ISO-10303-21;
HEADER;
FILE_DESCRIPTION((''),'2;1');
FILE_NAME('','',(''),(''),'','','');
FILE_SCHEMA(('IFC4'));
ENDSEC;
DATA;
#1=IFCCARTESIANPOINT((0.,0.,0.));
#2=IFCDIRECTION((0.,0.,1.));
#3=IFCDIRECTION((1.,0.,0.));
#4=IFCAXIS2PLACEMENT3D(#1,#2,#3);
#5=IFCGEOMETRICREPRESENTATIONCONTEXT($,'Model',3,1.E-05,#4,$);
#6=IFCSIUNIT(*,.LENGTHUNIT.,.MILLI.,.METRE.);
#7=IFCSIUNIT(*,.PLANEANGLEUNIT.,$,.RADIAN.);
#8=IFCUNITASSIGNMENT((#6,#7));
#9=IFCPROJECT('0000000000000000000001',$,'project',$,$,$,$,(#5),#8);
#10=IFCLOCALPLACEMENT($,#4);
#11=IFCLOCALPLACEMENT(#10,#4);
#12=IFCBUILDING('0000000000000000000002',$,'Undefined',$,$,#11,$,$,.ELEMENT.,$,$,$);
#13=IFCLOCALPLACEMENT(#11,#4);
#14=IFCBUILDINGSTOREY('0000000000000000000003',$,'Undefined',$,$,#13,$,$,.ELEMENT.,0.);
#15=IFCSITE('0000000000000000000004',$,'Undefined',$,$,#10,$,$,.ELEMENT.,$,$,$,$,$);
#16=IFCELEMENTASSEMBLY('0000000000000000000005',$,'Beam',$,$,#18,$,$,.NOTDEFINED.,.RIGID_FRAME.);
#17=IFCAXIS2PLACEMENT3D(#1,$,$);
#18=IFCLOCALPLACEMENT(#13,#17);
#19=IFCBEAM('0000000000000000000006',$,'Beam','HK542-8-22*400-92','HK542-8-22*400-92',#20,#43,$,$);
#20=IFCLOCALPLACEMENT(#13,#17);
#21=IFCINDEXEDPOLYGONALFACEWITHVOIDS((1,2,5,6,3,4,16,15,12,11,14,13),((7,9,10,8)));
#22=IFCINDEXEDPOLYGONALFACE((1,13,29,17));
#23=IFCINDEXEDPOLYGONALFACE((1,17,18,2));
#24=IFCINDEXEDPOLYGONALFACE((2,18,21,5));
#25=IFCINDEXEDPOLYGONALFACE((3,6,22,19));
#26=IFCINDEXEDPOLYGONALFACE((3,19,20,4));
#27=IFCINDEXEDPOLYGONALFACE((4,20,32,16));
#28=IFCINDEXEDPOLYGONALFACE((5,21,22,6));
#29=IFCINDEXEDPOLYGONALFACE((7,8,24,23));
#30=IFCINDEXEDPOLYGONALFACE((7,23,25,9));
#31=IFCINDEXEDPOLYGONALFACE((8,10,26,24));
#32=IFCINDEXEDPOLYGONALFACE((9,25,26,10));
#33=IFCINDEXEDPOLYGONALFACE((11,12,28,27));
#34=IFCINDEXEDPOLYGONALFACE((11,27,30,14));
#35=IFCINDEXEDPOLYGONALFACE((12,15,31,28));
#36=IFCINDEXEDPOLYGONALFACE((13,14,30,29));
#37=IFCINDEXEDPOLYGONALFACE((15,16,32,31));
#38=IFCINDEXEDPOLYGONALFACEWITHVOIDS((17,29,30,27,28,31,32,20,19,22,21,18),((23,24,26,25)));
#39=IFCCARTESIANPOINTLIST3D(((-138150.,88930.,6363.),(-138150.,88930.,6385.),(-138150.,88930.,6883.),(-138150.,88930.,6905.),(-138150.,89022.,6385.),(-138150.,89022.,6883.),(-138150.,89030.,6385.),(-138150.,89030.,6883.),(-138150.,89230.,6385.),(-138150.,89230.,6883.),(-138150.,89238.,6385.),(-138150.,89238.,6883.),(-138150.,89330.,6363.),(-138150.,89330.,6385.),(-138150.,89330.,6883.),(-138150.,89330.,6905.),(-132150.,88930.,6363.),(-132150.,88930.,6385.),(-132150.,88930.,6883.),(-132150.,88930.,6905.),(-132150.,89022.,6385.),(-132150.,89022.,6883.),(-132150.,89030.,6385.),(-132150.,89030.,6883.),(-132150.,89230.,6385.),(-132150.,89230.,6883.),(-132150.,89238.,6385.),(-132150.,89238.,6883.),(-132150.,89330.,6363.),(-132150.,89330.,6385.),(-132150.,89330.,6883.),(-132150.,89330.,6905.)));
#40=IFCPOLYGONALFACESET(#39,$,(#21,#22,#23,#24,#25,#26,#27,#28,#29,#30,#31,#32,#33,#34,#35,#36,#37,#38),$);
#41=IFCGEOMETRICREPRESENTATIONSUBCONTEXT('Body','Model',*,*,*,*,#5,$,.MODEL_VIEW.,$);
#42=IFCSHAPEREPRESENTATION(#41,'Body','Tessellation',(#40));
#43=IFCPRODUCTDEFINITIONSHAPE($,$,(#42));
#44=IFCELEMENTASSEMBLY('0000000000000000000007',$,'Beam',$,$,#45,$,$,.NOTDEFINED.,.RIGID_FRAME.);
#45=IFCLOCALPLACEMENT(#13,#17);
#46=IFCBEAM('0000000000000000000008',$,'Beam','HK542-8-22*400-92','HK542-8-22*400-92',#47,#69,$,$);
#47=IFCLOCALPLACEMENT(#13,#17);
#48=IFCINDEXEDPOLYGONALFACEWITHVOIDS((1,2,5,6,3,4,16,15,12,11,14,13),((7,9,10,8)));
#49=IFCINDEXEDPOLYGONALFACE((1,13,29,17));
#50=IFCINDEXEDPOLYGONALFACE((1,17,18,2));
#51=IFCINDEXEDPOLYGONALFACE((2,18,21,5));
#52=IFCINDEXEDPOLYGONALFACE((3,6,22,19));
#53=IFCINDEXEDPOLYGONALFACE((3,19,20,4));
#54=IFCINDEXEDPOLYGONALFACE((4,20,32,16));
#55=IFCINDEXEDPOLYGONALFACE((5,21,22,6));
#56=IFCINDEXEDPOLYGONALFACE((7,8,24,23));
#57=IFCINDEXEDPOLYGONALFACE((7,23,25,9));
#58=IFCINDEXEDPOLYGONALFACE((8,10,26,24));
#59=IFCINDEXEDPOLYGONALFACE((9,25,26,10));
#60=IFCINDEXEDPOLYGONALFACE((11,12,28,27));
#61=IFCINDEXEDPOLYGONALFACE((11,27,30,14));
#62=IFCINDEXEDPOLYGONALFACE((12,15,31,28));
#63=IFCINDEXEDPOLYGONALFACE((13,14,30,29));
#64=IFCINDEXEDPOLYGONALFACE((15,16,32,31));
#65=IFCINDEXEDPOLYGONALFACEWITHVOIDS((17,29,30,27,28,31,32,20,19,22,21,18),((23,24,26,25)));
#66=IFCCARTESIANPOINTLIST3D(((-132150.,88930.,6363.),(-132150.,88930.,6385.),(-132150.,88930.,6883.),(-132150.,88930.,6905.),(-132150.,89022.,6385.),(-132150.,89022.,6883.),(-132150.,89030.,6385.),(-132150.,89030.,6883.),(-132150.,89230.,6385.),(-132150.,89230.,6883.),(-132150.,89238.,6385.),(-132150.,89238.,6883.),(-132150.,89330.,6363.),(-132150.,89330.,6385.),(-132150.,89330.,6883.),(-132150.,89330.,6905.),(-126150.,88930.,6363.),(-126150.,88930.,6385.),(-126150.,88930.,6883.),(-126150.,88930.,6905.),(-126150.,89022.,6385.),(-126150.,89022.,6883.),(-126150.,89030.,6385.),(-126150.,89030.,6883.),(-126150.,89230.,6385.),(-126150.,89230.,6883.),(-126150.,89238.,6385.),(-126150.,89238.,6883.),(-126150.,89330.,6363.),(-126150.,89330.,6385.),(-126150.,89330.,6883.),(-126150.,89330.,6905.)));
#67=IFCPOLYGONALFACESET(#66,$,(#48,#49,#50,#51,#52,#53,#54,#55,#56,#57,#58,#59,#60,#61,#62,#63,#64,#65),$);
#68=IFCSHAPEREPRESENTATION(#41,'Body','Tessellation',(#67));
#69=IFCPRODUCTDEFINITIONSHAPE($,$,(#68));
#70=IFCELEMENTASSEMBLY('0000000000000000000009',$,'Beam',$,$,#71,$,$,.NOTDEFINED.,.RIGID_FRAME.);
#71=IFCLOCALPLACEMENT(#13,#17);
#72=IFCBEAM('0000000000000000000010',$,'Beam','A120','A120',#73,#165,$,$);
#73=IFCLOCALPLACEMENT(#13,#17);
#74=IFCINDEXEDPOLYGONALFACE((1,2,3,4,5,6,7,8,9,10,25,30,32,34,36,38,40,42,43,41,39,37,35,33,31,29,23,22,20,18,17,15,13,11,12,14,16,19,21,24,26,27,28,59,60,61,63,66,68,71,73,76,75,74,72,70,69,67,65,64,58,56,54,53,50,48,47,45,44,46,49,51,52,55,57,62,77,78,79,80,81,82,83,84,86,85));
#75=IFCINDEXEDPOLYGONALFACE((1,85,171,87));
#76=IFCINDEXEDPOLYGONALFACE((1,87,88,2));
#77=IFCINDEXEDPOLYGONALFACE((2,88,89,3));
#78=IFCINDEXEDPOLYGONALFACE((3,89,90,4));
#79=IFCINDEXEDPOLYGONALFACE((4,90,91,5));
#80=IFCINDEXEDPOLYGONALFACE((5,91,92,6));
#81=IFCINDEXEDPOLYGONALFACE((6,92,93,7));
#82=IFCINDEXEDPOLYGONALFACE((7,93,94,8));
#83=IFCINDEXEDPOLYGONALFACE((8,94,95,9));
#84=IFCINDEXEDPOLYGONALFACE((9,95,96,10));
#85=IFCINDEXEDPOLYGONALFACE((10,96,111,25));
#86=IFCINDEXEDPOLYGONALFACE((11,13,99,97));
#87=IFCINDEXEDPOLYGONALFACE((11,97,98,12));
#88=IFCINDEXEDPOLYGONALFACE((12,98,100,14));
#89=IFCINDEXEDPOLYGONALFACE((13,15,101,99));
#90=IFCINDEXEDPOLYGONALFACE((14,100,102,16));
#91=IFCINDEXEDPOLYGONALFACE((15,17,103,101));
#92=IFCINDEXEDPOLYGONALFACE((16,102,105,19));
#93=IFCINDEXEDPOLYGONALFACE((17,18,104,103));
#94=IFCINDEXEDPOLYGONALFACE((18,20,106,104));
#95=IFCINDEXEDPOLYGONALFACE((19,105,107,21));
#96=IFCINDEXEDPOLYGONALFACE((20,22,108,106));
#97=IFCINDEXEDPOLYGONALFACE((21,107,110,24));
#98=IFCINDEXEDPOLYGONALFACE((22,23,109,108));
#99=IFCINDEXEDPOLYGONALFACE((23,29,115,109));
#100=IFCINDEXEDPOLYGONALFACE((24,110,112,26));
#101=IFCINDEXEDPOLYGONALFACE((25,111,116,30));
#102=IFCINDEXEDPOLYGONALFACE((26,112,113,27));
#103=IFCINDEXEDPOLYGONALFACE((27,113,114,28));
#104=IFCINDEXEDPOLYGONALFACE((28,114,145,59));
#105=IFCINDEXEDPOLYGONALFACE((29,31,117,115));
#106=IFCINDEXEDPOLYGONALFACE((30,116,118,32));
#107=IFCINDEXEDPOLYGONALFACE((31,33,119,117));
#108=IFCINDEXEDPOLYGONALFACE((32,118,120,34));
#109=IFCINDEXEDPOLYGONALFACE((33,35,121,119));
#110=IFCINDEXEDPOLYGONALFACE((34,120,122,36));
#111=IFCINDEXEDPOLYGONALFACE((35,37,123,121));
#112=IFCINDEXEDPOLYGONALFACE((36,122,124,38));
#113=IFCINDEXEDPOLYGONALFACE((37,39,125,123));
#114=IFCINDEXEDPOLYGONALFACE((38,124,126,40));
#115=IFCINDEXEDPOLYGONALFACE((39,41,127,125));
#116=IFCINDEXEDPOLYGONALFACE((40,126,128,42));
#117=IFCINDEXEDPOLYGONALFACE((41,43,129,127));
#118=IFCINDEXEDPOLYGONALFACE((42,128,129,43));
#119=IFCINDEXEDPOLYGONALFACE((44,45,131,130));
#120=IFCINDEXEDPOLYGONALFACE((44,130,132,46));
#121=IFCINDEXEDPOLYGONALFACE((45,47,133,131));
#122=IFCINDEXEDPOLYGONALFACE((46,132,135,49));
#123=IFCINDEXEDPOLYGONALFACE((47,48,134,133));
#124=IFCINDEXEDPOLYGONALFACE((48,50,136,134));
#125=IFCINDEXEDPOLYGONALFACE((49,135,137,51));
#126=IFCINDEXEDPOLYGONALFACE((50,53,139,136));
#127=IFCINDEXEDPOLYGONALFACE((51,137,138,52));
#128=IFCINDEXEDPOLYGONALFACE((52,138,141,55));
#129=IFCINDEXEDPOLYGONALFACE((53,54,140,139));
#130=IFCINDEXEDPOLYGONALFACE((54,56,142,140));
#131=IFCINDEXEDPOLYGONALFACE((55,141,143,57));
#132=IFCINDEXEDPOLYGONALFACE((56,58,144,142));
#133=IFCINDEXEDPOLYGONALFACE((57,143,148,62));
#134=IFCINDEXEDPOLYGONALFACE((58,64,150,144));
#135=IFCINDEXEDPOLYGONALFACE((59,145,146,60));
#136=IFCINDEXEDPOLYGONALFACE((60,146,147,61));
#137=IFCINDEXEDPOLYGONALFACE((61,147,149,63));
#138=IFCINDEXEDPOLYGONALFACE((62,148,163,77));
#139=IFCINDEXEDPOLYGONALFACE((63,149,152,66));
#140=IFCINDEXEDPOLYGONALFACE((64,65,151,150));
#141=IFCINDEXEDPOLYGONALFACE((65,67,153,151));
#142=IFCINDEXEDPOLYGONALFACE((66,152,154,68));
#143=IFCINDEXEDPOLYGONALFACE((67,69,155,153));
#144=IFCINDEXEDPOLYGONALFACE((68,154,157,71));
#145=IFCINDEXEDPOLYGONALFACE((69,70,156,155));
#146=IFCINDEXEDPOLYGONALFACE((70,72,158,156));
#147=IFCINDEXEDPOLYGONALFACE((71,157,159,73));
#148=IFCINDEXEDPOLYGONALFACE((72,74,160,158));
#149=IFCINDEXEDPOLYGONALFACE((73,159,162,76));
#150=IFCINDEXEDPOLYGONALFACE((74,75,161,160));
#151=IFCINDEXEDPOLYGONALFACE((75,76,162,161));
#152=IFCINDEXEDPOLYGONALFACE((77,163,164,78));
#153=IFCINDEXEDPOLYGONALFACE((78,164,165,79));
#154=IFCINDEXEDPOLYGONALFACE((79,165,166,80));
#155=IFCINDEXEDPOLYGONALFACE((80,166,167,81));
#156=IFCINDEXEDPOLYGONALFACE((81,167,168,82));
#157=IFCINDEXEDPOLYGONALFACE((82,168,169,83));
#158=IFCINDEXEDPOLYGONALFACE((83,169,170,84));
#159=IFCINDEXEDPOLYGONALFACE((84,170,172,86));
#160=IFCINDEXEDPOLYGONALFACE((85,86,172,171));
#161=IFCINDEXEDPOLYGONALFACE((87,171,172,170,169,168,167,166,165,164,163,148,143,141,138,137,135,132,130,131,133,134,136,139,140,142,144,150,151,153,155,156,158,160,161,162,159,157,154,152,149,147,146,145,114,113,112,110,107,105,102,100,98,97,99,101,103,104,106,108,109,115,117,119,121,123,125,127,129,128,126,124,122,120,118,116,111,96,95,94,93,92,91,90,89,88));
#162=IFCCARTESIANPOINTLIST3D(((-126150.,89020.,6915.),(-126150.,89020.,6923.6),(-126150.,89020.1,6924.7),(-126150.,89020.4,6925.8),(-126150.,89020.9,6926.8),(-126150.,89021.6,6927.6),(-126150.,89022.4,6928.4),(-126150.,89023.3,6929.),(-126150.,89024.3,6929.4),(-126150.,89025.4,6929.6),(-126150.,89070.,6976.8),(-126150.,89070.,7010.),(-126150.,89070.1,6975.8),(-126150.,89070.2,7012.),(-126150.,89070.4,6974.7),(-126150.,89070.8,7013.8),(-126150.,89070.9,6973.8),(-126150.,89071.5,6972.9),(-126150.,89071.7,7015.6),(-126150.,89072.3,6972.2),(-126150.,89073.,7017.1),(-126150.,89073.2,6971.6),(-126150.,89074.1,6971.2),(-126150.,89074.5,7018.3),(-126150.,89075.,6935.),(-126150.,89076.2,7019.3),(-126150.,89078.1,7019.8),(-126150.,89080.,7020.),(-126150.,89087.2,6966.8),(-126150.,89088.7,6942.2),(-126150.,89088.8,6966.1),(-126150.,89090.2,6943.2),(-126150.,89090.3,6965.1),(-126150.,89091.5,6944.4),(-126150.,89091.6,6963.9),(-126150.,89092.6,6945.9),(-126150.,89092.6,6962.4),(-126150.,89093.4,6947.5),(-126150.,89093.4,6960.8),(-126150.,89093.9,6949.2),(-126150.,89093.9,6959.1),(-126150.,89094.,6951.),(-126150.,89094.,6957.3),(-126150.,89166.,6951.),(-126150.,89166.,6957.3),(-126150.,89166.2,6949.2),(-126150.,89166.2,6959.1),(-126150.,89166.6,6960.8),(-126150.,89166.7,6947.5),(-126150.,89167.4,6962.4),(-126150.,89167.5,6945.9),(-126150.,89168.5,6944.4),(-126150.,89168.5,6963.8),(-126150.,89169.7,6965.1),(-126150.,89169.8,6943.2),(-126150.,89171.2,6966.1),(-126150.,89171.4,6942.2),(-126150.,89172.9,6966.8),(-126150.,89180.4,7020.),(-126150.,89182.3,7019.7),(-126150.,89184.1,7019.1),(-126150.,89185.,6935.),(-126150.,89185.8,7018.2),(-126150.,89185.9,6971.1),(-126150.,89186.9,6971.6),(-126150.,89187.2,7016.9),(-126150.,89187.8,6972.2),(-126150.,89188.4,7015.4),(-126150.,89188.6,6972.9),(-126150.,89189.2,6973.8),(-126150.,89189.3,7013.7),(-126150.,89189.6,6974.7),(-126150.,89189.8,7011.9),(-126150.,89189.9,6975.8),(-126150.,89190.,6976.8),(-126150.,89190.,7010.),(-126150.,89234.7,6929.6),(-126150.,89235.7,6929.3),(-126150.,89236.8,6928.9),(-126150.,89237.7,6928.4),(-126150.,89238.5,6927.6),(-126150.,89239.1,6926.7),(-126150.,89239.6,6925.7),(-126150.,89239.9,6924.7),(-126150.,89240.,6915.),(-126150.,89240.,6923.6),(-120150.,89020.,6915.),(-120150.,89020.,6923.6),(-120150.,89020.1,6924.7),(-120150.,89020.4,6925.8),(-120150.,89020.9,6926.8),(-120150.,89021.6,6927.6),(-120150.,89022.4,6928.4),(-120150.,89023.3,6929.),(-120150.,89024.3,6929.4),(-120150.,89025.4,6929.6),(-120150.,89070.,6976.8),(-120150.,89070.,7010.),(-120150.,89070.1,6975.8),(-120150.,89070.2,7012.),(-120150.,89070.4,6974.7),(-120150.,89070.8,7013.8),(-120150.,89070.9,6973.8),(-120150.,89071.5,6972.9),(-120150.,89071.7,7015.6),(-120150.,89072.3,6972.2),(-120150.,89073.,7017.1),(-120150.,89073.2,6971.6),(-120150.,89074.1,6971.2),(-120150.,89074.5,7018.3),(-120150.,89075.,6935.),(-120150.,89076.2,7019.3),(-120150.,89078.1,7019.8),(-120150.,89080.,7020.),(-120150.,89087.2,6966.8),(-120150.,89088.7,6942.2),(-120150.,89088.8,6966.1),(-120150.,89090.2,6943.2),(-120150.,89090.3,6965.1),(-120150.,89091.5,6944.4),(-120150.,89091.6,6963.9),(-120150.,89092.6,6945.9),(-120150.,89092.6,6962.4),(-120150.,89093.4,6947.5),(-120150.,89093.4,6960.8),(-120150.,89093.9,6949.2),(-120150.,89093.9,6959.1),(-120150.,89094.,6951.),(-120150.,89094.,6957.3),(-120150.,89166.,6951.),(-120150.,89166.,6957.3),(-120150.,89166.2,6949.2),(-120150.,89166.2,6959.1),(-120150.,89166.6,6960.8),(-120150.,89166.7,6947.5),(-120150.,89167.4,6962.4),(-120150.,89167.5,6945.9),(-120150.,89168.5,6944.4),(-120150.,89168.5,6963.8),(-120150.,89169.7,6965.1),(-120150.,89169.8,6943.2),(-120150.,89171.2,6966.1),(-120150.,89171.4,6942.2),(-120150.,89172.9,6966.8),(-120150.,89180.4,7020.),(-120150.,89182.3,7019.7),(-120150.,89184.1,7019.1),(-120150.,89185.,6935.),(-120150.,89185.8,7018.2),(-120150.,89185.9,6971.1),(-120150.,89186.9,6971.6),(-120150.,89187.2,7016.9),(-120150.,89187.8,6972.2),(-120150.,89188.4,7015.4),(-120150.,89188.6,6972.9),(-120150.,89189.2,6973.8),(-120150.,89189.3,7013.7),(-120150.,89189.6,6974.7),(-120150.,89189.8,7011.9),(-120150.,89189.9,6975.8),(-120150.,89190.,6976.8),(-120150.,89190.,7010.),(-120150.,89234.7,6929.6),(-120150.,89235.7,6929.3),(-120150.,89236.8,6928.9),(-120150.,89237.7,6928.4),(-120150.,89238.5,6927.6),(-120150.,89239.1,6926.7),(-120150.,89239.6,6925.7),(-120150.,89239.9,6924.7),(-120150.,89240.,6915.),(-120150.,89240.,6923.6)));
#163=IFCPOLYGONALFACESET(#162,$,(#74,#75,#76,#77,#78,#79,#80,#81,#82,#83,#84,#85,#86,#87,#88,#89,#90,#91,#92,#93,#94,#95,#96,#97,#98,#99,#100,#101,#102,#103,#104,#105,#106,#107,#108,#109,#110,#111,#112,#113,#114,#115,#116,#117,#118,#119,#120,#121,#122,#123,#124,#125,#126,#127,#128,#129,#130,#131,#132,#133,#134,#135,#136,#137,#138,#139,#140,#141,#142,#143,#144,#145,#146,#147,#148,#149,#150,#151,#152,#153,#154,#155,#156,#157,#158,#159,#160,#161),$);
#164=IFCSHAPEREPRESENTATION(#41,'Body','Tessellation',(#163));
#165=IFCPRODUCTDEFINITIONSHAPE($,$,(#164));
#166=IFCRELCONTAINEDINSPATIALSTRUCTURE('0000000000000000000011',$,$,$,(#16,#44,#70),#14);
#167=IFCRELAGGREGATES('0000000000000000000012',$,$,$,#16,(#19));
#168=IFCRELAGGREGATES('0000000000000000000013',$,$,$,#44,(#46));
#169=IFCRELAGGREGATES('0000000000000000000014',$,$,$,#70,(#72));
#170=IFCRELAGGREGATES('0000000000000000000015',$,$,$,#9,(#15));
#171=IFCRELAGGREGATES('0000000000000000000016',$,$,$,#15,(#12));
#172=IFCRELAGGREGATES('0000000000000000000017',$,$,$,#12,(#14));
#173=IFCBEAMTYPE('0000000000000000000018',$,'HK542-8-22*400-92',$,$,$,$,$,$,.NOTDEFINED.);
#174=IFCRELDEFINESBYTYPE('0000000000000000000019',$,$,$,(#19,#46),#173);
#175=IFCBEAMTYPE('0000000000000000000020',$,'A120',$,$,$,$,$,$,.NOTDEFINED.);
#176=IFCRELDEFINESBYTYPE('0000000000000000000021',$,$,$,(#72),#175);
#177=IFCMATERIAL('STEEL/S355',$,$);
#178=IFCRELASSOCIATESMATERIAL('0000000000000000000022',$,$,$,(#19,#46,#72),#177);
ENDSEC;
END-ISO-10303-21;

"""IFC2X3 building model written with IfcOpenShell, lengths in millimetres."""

from ifc_helpers import new_model, si_unit, frame, origin_with_axes, place, context, subcontext, project, spatial, polyline, outline, extrude, material, type_object, element, aggregate, save


model = new_model("IFC2X3")

# Units and contexts
model_context = context("Model", 3, precision=1e-05, world=origin_with_axes())
body_context = subcontext(model_context, "Body", "Model", "MODEL_VIEW")
ifc_project = project(units=[si_unit("LENGTHUNIT", "METRE", prefix="MILLI"), si_unit("PLANEANGLEUNIT", "RADIAN")], contexts=[model_context])

# Site, building, storey
site_placement = place(None, origin_with_axes())
site = spatial("IfcSite", under=ifc_project, at=site_placement, Name="Undefined", CompositionType="ELEMENT")
building_placement = place(site_placement, origin_with_axes())
building = spatial("IfcBuilding", under=site, at=building_placement, Name="Undefined", CompositionType="ELEMENT")
storey_placement = place(building_placement, origin_with_axes())
storey = spatial("IfcBuildingStorey", under=building, at=storey_placement, Name="Undefined", CompositionType="ELEMENT", Elevation=0.0)

# Element assemblies, beams
assembly_1_placement = place(storey_placement, origin_with_axes())
assembly_1 = element("IfcElementAssembly", 1, at=assembly_1_placement, inside=storey, Name="Beam", AssemblyPlace="NOTDEFINED", PredefinedType="RIGID_FRAME")
ifc_material_1 = material(Name="STEEL/S355")
beam_type_1 = type_object("IfcBeamType", Name="HK542-8-22*400-92", PredefinedType="NOTDEFINED")
beam_1_placement = place(assembly_1_placement, frame((-132150.0, 89130.0, 6634.0), z_axis=(0.0, 0.0, 1.0), x_axis=(-1.0, 0.0, 0.0)))
beam_1 = element("IfcBeam", 2, at=beam_1_placement, type_object=beam_type_1, material=ifc_material_1, Name="Beam", Description="HK542-8-22*400-92", ObjectType="HK542-8-22*400-92", context=body_context, shape_type="SweptSolid", body=[
    extrude(outline(polyline([(-200.0, 249.0), (-200.0, 271.0), (200.0, 271.0), (200.0, 249.0), (108.0, 249.0), (108.0, -249.0), (200.0, -249.0), (200.0, -271.0), (-200.0, -271.0), (-200.0, -249.0), (-108.0, -249.0), (-108.0, 249.0), (-200.0, 249.0)]), holes=[polyline([(-100.0, -249.0), (100.0, -249.0), (100.0, 249.0), (-100.0, 249.0), (-100.0, -249.0)])]), frame((6000.0, 0.0, 0.0), z_axis=(-1.0, 0.0, 0.0), x_axis=(0.0, -1.0, 0.0)), (0.0, 0.0, 1.0), 6000.0),
])
aggregate(assembly_1, [beam_1])
assembly_2_placement = place(storey_placement, origin_with_axes())
assembly_2 = element("IfcElementAssembly", 3, at=assembly_2_placement, inside=storey, Name="Beam", AssemblyPlace="NOTDEFINED", PredefinedType="RIGID_FRAME")
beam_2_placement = place(assembly_2_placement, frame((-126150.0, 89130.0, 6634.0), z_axis=(0.0, 0.0, 1.0), x_axis=(-1.0, 0.0, 0.0)))
beam_2 = element("IfcBeam", 4, at=beam_2_placement, type_object=beam_type_1, material=ifc_material_1, Name="Beam", Description="HK542-8-22*400-92", ObjectType="HK542-8-22*400-92", context=body_context, shape_type="SweptSolid", body=[
    extrude(outline(polyline([(-200.0, 249.0), (-200.0, 271.0), (200.0, 271.0), (200.0, 249.0), (108.0, 249.0), (108.0, -249.0), (200.0, -249.0), (200.0, -271.0), (-200.0, -271.0), (-200.0, -249.0), (-108.0, -249.0), (-108.0, 249.0), (-200.0, 249.0)]), holes=[polyline([(-100.0, -249.0), (100.0, -249.0), (100.0, 249.0), (-100.0, 249.0), (-100.0, -249.0)])]), frame((6000.0, 0.0, 0.0), z_axis=(-1.0, 0.0, 0.0), x_axis=(0.0, -1.0, 0.0)), (0.0, 0.0, 1.0), 6000.0),
])
aggregate(assembly_2, [beam_2])
assembly_3_placement = place(storey_placement, origin_with_axes())
assembly_3 = element("IfcElementAssembly", 5, at=assembly_3_placement, inside=storey, Name="Beam", AssemblyPlace="NOTDEFINED", PredefinedType="RIGID_FRAME")
beam_type_2 = type_object("IfcBeamType", Name="A120", PredefinedType="NOTDEFINED")
beam_3_placement = place(assembly_3_placement, frame((-126150.0, 89130.0, 6967.5), z_axis=(0.0, 0.000118, 1.0), x_axis=(1.0, 0.0, 0.0)))
beam_3 = element("IfcBeam", 6, at=beam_3_placement, type_object=beam_type_2, material=ifc_material_1, Name="Beam", Description="A120", ObjectType="A120", context=body_context, shape_type="SweptSolid", body=[
    extrude(outline(polyline([(-110.0, -52.5), (-110.0, -43.9), (-109.9, -42.8), (-109.6, -41.8), (-109.1, -40.8), (-108.5, -39.9), (-107.7, -39.1), (-106.7, -38.6), (-105.7, -38.2), (-104.7, -37.9), (-55.0, -32.5), (-41.3, -25.3), (-39.8, -24.3), (-38.5, -23.1), (-37.4, -21.6), (-36.6, -20.0), (-36.2, -18.3), (-36.0, -16.5), (-36.0, -10.2), (-36.1, -8.4), (-36.6, -6.7), (-37.4, -5.1), (-38.4, -3.7), (-39.7, -2.4), (-41.2, -1.4), (-42.8, -0.7), (-55.9, 3.6), (-56.9, 4.1), (-57.8, 4.7), (-58.5, 5.4), (-59.2, 6.3), (-59.6, 7.2), (-59.9, 8.3), (-60.0, 9.3), (-60.0, 42.5), (-59.8, 44.4), (-59.3, 46.2), (-58.4, 47.9), (-57.2, 49.4), (-55.7, 50.7), (-54.1, 51.6), (-52.3, 52.2), (-50.4, 52.5), (50.0, 52.5), (51.9, 52.3), (53.8, 51.7), (55.5, 50.8), (57.1, 49.6), (58.3, 48.1), (59.2, 46.3), (59.8, 44.4), (60.0, 42.5), (60.0, 9.3), (59.9, 8.3), (59.6, 7.2), (59.2, 6.3), (58.5, 5.4), (57.8, 4.7), (56.9, 4.1), (55.9, 3.6), (42.8, -0.7), (41.2, -1.4), (39.7, -2.4), (38.4, -3.7), (37.4, -5.1), (36.6, -6.7), (36.1, -8.4), (36.0, -10.2), (36.0, -16.5), (36.2, -18.3), (36.6, -20.0), (37.4, -21.6), (38.5, -23.1), (39.8, -24.3), (41.3, -25.3), (55.0, -32.5), (104.7, -37.9), (105.7, -38.2), (106.7, -38.6), (107.7, -39.1), (108.5, -39.9), (109.1, -40.8), (109.6, -41.8), (109.9, -42.8), (110.0, -43.9), (110.0, -52.5), (-110.0, -52.5)])), frame((6000.0, 0.0, 0.0), z_axis=(-1.0, 0.0, 0.0), x_axis=(0.0, -1.0, 0.0)), (0.0, 0.0, 1.0), 6000.0),
])
aggregate(assembly_3, [beam_3])

save(model, "model.ifc")
